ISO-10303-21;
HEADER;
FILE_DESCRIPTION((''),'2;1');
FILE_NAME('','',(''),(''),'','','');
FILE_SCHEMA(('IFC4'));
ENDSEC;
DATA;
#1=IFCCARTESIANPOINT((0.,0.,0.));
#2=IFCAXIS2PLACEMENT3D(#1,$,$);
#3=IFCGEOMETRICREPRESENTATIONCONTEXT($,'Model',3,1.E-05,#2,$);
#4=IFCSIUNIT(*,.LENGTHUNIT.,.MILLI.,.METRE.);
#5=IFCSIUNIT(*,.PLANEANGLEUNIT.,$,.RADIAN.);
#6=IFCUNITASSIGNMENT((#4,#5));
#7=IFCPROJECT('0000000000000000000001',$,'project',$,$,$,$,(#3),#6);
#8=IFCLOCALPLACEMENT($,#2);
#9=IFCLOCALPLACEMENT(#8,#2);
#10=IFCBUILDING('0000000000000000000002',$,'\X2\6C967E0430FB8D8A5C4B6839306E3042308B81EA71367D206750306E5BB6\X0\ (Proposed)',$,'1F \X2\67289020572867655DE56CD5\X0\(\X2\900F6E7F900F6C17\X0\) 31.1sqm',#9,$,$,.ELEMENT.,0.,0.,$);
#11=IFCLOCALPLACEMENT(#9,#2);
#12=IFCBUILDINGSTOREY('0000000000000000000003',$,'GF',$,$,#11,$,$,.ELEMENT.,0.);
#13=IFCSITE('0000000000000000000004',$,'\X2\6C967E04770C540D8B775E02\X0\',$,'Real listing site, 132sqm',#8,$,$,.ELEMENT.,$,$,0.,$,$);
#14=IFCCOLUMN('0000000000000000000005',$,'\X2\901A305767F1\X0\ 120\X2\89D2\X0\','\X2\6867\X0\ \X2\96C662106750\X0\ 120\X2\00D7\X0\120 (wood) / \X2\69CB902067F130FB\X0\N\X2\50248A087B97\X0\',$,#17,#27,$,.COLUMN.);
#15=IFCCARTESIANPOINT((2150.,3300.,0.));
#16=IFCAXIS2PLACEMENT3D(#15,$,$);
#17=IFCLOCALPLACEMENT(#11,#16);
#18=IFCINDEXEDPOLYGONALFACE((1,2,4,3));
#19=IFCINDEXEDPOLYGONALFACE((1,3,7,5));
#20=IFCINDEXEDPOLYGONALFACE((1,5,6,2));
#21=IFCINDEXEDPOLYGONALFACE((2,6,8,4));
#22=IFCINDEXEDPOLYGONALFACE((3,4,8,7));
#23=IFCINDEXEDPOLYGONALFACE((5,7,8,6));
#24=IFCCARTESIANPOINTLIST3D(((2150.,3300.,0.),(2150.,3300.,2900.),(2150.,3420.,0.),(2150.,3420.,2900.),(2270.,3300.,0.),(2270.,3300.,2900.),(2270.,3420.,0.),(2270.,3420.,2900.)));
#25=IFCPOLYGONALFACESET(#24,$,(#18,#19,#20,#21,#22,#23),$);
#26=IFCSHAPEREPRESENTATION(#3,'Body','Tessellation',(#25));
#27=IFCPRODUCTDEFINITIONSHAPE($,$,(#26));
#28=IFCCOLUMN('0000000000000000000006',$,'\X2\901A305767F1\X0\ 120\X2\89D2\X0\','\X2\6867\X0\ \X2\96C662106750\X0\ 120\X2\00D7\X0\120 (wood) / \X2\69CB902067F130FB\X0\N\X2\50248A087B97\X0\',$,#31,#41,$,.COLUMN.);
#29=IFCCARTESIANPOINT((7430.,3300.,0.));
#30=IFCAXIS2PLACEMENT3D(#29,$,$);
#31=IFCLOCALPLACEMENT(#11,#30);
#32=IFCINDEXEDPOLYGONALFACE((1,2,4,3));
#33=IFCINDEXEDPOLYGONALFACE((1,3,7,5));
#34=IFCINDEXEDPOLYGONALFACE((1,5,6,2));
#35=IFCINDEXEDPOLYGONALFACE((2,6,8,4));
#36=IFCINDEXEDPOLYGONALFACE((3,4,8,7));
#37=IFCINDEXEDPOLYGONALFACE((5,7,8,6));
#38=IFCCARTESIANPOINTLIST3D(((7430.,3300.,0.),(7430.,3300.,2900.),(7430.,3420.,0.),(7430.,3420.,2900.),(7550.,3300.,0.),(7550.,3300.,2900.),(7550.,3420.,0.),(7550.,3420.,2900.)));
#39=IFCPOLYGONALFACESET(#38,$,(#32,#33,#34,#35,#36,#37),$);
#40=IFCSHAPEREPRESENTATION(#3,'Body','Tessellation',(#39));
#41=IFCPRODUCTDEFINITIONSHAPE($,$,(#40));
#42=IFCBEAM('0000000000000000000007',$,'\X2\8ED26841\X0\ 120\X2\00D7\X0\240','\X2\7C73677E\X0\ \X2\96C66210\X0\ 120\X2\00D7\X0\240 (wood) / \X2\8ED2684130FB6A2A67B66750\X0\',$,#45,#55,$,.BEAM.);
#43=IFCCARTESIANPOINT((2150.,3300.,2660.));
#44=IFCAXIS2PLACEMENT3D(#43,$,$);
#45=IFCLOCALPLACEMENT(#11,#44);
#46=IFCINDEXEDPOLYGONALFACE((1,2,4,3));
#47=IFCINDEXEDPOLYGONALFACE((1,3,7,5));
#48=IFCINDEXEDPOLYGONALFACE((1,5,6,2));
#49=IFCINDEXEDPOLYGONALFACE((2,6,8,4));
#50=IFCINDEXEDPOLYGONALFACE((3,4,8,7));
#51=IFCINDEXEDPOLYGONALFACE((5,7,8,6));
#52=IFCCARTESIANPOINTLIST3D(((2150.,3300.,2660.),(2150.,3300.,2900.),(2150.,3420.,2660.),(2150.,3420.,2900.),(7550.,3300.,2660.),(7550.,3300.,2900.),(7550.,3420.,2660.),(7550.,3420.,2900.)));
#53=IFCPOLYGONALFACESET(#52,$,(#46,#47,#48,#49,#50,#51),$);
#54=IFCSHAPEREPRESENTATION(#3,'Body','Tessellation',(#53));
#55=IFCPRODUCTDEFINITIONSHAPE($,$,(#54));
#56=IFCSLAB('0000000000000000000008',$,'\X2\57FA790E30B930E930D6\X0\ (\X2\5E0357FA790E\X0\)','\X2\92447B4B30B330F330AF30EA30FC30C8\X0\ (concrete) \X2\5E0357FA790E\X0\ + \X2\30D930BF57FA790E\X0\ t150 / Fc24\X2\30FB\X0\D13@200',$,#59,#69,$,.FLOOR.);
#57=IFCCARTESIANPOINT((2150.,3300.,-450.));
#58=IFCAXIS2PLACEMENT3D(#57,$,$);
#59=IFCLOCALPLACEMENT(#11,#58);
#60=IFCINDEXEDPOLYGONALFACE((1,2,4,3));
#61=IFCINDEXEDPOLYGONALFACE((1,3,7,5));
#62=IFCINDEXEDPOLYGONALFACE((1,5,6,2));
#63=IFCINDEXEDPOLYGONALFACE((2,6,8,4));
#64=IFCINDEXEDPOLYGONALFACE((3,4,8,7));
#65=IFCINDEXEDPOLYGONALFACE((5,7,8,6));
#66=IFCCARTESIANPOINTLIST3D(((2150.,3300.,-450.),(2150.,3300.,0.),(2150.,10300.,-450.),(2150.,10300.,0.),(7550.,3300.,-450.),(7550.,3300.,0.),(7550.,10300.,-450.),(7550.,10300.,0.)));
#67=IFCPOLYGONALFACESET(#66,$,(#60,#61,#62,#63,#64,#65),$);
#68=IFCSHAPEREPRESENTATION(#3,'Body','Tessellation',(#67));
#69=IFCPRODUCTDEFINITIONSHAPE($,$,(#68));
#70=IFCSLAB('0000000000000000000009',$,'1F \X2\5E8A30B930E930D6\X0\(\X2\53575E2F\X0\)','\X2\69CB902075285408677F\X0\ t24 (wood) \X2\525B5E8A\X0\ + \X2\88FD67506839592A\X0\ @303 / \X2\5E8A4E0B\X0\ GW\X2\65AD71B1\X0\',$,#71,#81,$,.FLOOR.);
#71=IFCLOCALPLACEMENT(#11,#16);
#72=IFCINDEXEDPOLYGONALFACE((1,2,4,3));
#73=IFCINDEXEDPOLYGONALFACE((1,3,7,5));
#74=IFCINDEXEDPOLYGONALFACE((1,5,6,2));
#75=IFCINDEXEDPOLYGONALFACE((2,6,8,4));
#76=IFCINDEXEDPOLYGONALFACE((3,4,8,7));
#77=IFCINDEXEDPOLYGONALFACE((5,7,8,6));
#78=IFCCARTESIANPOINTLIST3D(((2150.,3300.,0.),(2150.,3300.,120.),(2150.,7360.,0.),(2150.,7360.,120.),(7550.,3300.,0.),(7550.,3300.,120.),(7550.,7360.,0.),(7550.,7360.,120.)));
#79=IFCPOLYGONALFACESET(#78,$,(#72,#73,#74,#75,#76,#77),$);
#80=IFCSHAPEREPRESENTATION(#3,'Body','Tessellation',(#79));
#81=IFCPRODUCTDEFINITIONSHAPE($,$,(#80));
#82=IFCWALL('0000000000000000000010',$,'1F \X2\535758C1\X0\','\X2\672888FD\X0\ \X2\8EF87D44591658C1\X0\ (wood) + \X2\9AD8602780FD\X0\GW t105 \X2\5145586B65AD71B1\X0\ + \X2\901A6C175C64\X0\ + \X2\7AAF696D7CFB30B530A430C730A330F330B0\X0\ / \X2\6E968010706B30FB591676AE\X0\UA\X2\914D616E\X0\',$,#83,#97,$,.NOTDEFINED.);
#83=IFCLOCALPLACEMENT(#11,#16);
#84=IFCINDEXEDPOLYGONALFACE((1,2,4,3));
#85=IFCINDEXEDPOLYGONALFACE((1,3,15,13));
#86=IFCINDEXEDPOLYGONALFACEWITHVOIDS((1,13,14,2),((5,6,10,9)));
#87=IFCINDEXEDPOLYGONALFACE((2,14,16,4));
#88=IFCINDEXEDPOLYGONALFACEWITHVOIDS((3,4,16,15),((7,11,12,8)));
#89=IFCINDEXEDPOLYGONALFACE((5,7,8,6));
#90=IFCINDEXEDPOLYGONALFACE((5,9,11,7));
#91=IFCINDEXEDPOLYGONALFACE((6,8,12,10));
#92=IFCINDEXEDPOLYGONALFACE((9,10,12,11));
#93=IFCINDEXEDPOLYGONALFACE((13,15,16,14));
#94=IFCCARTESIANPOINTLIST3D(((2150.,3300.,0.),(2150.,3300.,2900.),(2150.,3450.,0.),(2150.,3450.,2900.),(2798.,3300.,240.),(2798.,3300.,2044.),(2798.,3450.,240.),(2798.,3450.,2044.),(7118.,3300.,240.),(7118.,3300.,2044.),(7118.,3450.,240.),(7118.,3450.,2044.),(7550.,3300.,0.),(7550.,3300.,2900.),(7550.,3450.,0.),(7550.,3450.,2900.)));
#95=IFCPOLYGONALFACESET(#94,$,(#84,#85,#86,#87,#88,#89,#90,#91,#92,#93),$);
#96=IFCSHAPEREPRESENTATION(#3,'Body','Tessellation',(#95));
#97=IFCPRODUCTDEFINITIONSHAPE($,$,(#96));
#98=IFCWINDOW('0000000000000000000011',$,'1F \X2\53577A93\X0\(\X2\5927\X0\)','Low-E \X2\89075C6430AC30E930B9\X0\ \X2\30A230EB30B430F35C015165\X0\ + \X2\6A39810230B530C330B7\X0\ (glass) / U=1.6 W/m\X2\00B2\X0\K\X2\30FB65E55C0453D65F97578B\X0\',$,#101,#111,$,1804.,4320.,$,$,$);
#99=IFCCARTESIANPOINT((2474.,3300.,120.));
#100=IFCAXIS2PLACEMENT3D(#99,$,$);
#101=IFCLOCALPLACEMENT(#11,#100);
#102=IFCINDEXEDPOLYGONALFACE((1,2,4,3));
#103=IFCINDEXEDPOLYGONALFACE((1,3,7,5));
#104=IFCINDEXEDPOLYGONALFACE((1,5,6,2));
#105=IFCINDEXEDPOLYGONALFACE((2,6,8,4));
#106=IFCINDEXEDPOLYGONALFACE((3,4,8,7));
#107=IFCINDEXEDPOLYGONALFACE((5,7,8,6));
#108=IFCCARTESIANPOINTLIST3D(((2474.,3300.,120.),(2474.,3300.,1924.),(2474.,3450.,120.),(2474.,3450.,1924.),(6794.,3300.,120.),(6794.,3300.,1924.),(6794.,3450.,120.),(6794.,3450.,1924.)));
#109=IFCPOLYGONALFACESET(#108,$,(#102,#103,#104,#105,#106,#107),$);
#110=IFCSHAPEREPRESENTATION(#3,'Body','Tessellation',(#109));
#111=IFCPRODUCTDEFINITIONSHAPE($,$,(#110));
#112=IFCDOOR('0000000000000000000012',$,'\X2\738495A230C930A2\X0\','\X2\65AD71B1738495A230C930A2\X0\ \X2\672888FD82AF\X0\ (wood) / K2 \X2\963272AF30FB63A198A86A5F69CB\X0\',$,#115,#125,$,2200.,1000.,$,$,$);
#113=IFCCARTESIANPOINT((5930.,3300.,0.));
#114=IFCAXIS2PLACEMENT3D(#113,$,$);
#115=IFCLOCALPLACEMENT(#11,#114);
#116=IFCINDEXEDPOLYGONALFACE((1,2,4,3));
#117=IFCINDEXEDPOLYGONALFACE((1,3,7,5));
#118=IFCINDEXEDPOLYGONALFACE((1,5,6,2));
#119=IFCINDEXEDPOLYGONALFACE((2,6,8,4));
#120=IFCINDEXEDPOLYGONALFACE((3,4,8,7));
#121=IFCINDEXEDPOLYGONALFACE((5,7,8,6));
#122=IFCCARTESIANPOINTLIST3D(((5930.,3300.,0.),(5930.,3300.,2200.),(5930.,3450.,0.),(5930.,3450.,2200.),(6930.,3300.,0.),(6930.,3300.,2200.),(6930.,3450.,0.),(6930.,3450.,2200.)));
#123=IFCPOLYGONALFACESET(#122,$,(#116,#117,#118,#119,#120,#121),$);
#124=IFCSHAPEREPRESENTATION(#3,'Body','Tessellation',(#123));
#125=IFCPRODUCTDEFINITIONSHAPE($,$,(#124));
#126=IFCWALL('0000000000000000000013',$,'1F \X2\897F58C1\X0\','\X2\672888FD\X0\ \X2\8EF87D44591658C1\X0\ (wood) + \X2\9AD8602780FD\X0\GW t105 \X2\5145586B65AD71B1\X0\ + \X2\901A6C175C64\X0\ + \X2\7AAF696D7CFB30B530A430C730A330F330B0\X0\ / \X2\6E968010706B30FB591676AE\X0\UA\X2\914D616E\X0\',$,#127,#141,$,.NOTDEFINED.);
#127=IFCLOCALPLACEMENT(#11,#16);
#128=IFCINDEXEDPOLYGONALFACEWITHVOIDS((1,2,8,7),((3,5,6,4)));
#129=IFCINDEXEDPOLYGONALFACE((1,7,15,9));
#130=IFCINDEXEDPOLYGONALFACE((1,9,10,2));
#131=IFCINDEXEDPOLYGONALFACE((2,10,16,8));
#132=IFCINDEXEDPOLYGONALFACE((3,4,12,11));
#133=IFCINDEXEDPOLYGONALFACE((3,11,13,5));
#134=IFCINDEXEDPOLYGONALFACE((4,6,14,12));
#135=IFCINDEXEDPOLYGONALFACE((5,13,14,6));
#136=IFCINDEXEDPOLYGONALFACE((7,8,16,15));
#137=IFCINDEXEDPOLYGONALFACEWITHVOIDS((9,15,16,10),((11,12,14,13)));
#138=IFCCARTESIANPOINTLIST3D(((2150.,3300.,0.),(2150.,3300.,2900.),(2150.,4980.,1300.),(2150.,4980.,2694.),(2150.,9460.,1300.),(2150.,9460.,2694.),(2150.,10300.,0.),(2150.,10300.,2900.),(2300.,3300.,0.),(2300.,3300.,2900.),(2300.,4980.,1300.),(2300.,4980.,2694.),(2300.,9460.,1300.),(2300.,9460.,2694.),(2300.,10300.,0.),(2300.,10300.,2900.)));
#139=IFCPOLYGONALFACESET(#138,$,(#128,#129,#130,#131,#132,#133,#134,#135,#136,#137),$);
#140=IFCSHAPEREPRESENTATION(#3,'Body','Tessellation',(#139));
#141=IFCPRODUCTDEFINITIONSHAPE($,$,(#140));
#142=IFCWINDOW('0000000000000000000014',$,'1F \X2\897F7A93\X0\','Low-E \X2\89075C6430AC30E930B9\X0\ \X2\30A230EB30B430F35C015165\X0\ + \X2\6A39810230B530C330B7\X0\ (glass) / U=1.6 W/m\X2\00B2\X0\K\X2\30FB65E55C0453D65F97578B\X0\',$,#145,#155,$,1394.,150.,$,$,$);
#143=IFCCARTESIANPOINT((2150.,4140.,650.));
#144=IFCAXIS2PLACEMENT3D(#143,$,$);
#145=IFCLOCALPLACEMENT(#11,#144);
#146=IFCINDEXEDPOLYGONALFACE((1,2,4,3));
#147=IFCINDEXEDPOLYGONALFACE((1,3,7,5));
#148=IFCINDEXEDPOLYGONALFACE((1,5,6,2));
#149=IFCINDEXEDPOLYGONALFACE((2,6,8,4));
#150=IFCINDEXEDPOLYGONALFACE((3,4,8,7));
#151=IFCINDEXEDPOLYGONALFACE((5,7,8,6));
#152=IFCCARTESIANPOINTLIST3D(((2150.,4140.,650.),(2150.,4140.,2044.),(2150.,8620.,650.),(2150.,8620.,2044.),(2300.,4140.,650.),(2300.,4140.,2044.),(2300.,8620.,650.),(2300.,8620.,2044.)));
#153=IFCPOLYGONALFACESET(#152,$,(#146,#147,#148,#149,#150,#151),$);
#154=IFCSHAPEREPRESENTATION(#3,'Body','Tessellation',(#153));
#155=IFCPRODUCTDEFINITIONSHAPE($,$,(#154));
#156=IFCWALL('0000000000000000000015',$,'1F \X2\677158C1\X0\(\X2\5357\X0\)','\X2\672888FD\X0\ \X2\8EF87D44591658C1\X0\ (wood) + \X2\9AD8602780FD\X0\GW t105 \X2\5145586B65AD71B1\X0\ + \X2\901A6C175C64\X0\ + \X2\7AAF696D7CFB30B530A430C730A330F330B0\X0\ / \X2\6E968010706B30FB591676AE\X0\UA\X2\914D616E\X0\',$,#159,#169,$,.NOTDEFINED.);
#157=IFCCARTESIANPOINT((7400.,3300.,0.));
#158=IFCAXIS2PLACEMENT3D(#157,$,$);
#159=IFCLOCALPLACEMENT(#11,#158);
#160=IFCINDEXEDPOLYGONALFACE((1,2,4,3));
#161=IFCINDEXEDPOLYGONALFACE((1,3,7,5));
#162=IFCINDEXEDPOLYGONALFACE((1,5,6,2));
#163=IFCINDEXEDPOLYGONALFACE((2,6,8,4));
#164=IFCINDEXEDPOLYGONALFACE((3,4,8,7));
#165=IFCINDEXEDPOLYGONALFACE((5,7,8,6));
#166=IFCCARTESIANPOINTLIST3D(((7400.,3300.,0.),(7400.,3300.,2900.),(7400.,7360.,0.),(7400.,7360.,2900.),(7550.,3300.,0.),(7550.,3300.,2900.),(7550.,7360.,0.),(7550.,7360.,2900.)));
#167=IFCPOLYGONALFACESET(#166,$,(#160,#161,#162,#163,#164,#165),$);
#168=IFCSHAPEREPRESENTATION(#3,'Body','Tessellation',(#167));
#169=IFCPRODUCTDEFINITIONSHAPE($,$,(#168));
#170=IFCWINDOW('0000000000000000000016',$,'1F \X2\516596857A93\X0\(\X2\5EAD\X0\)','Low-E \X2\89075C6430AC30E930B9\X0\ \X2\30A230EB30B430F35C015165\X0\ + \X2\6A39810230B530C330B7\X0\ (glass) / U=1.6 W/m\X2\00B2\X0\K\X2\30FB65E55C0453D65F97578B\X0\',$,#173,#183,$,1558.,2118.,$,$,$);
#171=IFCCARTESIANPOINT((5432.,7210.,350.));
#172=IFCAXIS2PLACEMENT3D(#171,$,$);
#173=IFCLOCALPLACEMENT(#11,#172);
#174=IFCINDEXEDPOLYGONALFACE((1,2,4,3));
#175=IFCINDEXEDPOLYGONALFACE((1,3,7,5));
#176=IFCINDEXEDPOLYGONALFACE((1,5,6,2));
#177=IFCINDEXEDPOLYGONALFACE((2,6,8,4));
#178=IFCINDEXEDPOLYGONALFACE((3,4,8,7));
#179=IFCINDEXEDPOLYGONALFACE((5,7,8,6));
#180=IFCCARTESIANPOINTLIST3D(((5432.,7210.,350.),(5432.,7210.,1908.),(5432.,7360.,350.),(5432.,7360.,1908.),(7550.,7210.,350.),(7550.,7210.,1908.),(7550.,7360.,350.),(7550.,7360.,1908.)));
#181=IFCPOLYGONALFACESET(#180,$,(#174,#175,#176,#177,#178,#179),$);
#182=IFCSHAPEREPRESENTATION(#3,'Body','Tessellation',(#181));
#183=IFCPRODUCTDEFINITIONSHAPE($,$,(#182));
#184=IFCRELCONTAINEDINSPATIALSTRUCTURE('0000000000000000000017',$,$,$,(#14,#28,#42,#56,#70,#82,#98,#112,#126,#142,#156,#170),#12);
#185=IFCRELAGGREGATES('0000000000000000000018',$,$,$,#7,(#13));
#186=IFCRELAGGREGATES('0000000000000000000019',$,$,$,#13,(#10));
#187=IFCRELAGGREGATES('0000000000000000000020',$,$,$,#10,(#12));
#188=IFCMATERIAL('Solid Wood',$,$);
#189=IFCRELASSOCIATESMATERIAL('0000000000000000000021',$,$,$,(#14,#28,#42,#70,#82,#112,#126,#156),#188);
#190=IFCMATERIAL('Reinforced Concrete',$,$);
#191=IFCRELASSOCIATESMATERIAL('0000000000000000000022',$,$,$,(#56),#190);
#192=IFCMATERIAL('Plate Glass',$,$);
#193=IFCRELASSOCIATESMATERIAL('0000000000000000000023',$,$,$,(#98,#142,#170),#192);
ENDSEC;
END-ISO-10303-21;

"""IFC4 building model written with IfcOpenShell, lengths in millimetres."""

from ifc_helpers import new_model, si_unit, frame, frame_2d, origin, place, context, project, spatial, rectangle, extrude, material, element, fill, save


model = new_model("IFC4")

# Units and contexts
model_context = context("Model", 3, precision=1e-05, world=origin())
ifc_project = project(units=[si_unit("LENGTHUNIT", "METRE", prefix="MILLI"), si_unit("PLANEANGLEUNIT", "RADIAN")], contexts=[model_context])

# Site, building, storey
site_placement = place(None, origin())
site = spatial("IfcSite", under=ifc_project, at=site_placement, Name="沖縄県名護市", ObjectType="Real listing site, 132sqm", CompositionType="ELEMENT", RefElevation=0.0)
building_placement = place(site_placement, origin())
building = spatial("IfcBuilding", under=site, at=building_placement, Name="沖縄・越屋根のある自然素材の家 (Proposed)", ObjectType="1F 木造在来工法(透湿透気) 31.1sqm", CompositionType="ELEMENT", ElevationOfRefHeight=0.0, ElevationOfTerrain=0.0)
storey_placement = place(building_placement, origin())
storey = spatial("IfcBuildingStorey", under=building, at=storey_placement, Name="GF", CompositionType="ELEMENT", Elevation=0.0)

# Columns
ifc_material_1 = material(Name="Solid Wood")
column_1_placement = place(storey_placement, frame((2150.0, 3300.0, 0.0)))
element("IfcColumn", 1, at=column_1_placement, inside=storey, material=ifc_material_1, Name="通し柱 120角", Description="桧 集成材 120×120 (wood) / 構造柱・N値計算", PredefinedType="COLUMN", context=model_context, shape_type="SweptSolid", body=[
    extrude(rectangle(XDim=120.0, YDim=120.0, at=frame_2d((60.0, 60.0))), frame((2150.0, 3300.0, 0.0)), (0.0, 0.0, 1.0), 2900.0),
])
column_2_placement = place(storey_placement, frame((7430.0, 3300.0, 0.0)))
element("IfcColumn", 2, at=column_2_placement, inside=storey, material=ifc_material_1, Name="通し柱 120角", Description="桧 集成材 120×120 (wood) / 構造柱・N値計算", PredefinedType="COLUMN", context=model_context, shape_type="SweptSolid", body=[
    extrude(rectangle(XDim=120.0, YDim=120.0, at=frame_2d((60.0, 60.0))), frame((7430.0, 3300.0, 0.0)), (0.0, 0.0, 1.0), 2900.0),
])

# Beam
beam_1_placement = place(storey_placement, frame((2150.0, 3300.0, 2660.0)))
element("IfcBeam", 3, at=beam_1_placement, inside=storey, material=ifc_material_1, Name="軒桁 120×240", Description="米松 集成 120×240 (wood) / 軒桁・横架材", PredefinedType="BEAM", context=model_context, shape_type="SweptSolid", body=[
    extrude(rectangle(XDim=5400.0, YDim=120.0, at=frame_2d((2700.0, 60.0))), frame((2150.0, 3300.0, 2660.0)), (0.0, 0.0, 1.0), 240.0),
])

# Slabs
ifc_material_2 = material(Name="Reinforced Concrete")
slab_1_placement = place(storey_placement, frame((2150.0, 3300.0, -450.0)))
element("IfcSlab", 4, at=slab_1_placement, inside=storey, material=ifc_material_2, Name="基礎スラブ (布基礎)", Description="鉄筋コンクリート (concrete) 布基礎 + ベタ基礎 t150 / Fc24・D13@200", PredefinedType="FLOOR", context=model_context, shape_type="SweptSolid", body=[
    extrude(rectangle(XDim=5400.0, YDim=7000.0, at=frame_2d((2700.0, 3500.0))), frame((2150.0, 3300.0, -450.0)), (0.0, 0.0, 1.0), 450.0),
])
slab_2_placement = place(storey_placement, frame((2150.0, 3300.0, 0.0)))
element("IfcSlab", 5, at=slab_2_placement, inside=storey, material=ifc_material_1, Name="1F 床スラブ(南帯)", Description="構造用合板 t24 (wood) 剛床 + 製材根太 @303 / 床下 GW断熱", PredefinedType="FLOOR", context=model_context, shape_type="SweptSolid", body=[
    extrude(rectangle(XDim=5400.0, YDim=4060.0, at=frame_2d((2700.0, 2030.0))), frame((2150.0, 3300.0, 0.0)), (0.0, 0.0, 1.0), 120.0),
])

# Wall, openings, window, door
wall_1_placement = place(storey_placement, frame((2150.0, 3300.0, 0.0)))
wall_1 = element("IfcWall", 6, at=wall_1_placement, inside=storey, material=ifc_material_1, Name="1F 南壁", Description="木製 軸組外壁 (wood) + 高性能GW t105 充填断熱 + 通気層 + 窯業系サイディング / 準耐火・外皮UA配慮", PredefinedType="NOTDEFINED", context=model_context, shape_type="SweptSolid", body=[
    extrude(rectangle(XDim=5400.0, YDim=150.0, at=frame_2d((2700.0, 75.0))), frame((2150.0, 3300.0, 0.0)), (0.0, 0.0, 1.0), 2900.0),
])
opening_1_placement = place(storey_placement, frame((2474.0, 3300.0, 120.0)))
opening_1 = element("IfcOpeningElement", 7, at=opening_1_placement, cuts=wall_1, PredefinedType="NOTDEFINED", context=model_context, shape_type="SweptSolid", body=[
    extrude(rectangle(XDim=4320.0, YDim=150.0, at=frame_2d((2160.0, 75.0))), frame((2474.0, 3300.0, 120.0)), (0.0, 0.0, 1.0), 1804.0),
])
opening_2_placement = place(storey_placement, frame((5930.0, 3300.0, 0.0)))
opening_2 = element("IfcOpeningElement", 8, at=opening_2_placement, cuts=wall_1, PredefinedType="NOTDEFINED", context=model_context, shape_type="SweptSolid", body=[
    extrude(rectangle(XDim=1000.0, YDim=150.0, at=frame_2d((500.0, 75.0))), frame((5930.0, 3300.0, 0.0)), (0.0, 0.0, 1.0), 2200.0),
])
ifc_material_3 = material(Name="Plate Glass")
window_1_placement = place(storey_placement, frame((2474.0, 3300.0, 120.0)))
window_1 = element("IfcWindow", 9, at=window_1_placement, inside=storey, material=ifc_material_3, Name="1F 南窓(大)", Description="Low-E 複層ガラス アルゴン封入 + 樹脂サッシ (glass) / U=1.6 W/m²K・日射取得型", OverallHeight=1804.0, OverallWidth=4320.0, context=model_context, shape_type="SweptSolid", body=[
    extrude(rectangle(XDim=4320.0, YDim=150.0, at=frame_2d((2160.0, 75.0))), frame((2474.0, 3300.0, 120.0)), (0.0, 0.0, 1.0), 1804.0),
])
fill(opening_1, window_1)
door_1_placement = place(storey_placement, frame((5930.0, 3300.0, 0.0)))
door_1 = element("IfcDoor", 10, at=door_1_placement, inside=storey, material=ifc_material_1, Name="玄関ドア", Description="断熱玄関ドア 木製芯 (wood) / K2 防犯・採風機構", OverallHeight=2200.0, OverallWidth=1000.0, context=model_context, shape_type="SweptSolid", body=[
    extrude(rectangle(XDim=1000.0, YDim=150.0, at=frame_2d((500.0, 75.0))), frame((5930.0, 3300.0, 0.0)), (0.0, 0.0, 1.0), 2200.0),
])
fill(opening_2, door_1)

# Walls, openings, windows
wall_2_placement = place(storey_placement, frame((2150.0, 3300.0, 0.0)))
wall_2 = element("IfcWall", 11, at=wall_2_placement, inside=storey, material=ifc_material_1, Name="1F 西壁", Description="木製 軸組外壁 (wood) + 高性能GW t105 充填断熱 + 通気層 + 窯業系サイディング / 準耐火・外皮UA配慮", PredefinedType="NOTDEFINED", context=model_context, shape_type="SweptSolid", body=[
    extrude(rectangle(XDim=150.0, YDim=7000.0, at=frame_2d((75.0, 3500.0))), frame((2150.0, 3300.0, 0.0)), (0.0, 0.0, 1.0), 2900.0),
])
opening_3_placement = place(storey_placement, frame((2150.0, 4140.0, 650.0)))
opening_3 = element("IfcOpeningElement", 12, at=opening_3_placement, cuts=wall_2, PredefinedType="NOTDEFINED", context=model_context, shape_type="SweptSolid", body=[
    extrude(rectangle(XDim=150.0, YDim=4480.0, at=frame_2d((75.0, 2240.0))), frame((2150.0, 4140.0, 650.0)), (0.0, 0.0, 1.0), 1394.0),
])
window_2_placement = place(storey_placement, frame((2150.0, 4140.0, 650.0)))
window_2 = element("IfcWindow", 13, at=window_2_placement, inside=storey, material=ifc_material_3, Name="1F 西窓", Description="Low-E 複層ガラス アルゴン封入 + 樹脂サッシ (glass) / U=1.6 W/m²K・日射取得型", OverallHeight=1394.0, OverallWidth=150.0, context=model_context, shape_type="SweptSolid", body=[
    extrude(rectangle(XDim=150.0, YDim=4480.0, at=frame_2d((75.0, 2240.0))), frame((2150.0, 4140.0, 650.0)), (0.0, 0.0, 1.0), 1394.0),
])
fill(opening_3, window_2)
wall_3_placement = place(storey_placement, frame((7400.0, 3300.0, 0.0)))
wall_3 = element("IfcWall", 14, at=wall_3_placement, inside=storey, material=ifc_material_1, Name="1F 東壁(南)", Description="木製 軸組外壁 (wood) + 高性能GW t105 充填断熱 + 通気層 + 窯業系サイディング / 準耐火・外皮UA配慮", PredefinedType="NOTDEFINED", context=model_context, shape_type="SweptSolid", body=[
    extrude(rectangle(XDim=150.0, YDim=4060.0, at=frame_2d((75.0, 2030.0))), frame((7400.0, 3300.0, 0.0)), (0.0, 0.0, 1.0), 2900.0),
])
opening_4_placement = place(storey_placement, frame((5432.0, 7210.0, 350.0)))
opening_4 = element("IfcOpeningElement", 15, at=opening_4_placement, cuts=wall_3, PredefinedType="NOTDEFINED", context=model_context, shape_type="SweptSolid", body=[
    extrude(rectangle(XDim=2118.0, YDim=150.0, at=frame_2d((1059.0, 75.0))), frame((5432.0, 7210.0, 350.0)), (0.0, 0.0, 1.0), 1558.0),
])
window_3_placement = place(storey_placement, frame((5432.0, 7210.0, 350.0)))
window_3 = element("IfcWindow", 16, at=window_3_placement, inside=storey, material=ifc_material_3, Name="1F 入隅窓(庭)", Description="Low-E 複層ガラス アルゴン封入 + 樹脂サッシ (glass) / U=1.6 W/m²K・日射取得型", OverallHeight=1558.0, OverallWidth=2118.0, context=model_context, shape_type="SweptSolid", body=[
    extrude(rectangle(XDim=2118.0, YDim=150.0, at=frame_2d((1059.0, 75.0))), frame((5432.0, 7210.0, 350.0)), (0.0, 0.0, 1.0), 1558.0),
])
fill(opening_4, window_3)

save(model, "model.ifc")
